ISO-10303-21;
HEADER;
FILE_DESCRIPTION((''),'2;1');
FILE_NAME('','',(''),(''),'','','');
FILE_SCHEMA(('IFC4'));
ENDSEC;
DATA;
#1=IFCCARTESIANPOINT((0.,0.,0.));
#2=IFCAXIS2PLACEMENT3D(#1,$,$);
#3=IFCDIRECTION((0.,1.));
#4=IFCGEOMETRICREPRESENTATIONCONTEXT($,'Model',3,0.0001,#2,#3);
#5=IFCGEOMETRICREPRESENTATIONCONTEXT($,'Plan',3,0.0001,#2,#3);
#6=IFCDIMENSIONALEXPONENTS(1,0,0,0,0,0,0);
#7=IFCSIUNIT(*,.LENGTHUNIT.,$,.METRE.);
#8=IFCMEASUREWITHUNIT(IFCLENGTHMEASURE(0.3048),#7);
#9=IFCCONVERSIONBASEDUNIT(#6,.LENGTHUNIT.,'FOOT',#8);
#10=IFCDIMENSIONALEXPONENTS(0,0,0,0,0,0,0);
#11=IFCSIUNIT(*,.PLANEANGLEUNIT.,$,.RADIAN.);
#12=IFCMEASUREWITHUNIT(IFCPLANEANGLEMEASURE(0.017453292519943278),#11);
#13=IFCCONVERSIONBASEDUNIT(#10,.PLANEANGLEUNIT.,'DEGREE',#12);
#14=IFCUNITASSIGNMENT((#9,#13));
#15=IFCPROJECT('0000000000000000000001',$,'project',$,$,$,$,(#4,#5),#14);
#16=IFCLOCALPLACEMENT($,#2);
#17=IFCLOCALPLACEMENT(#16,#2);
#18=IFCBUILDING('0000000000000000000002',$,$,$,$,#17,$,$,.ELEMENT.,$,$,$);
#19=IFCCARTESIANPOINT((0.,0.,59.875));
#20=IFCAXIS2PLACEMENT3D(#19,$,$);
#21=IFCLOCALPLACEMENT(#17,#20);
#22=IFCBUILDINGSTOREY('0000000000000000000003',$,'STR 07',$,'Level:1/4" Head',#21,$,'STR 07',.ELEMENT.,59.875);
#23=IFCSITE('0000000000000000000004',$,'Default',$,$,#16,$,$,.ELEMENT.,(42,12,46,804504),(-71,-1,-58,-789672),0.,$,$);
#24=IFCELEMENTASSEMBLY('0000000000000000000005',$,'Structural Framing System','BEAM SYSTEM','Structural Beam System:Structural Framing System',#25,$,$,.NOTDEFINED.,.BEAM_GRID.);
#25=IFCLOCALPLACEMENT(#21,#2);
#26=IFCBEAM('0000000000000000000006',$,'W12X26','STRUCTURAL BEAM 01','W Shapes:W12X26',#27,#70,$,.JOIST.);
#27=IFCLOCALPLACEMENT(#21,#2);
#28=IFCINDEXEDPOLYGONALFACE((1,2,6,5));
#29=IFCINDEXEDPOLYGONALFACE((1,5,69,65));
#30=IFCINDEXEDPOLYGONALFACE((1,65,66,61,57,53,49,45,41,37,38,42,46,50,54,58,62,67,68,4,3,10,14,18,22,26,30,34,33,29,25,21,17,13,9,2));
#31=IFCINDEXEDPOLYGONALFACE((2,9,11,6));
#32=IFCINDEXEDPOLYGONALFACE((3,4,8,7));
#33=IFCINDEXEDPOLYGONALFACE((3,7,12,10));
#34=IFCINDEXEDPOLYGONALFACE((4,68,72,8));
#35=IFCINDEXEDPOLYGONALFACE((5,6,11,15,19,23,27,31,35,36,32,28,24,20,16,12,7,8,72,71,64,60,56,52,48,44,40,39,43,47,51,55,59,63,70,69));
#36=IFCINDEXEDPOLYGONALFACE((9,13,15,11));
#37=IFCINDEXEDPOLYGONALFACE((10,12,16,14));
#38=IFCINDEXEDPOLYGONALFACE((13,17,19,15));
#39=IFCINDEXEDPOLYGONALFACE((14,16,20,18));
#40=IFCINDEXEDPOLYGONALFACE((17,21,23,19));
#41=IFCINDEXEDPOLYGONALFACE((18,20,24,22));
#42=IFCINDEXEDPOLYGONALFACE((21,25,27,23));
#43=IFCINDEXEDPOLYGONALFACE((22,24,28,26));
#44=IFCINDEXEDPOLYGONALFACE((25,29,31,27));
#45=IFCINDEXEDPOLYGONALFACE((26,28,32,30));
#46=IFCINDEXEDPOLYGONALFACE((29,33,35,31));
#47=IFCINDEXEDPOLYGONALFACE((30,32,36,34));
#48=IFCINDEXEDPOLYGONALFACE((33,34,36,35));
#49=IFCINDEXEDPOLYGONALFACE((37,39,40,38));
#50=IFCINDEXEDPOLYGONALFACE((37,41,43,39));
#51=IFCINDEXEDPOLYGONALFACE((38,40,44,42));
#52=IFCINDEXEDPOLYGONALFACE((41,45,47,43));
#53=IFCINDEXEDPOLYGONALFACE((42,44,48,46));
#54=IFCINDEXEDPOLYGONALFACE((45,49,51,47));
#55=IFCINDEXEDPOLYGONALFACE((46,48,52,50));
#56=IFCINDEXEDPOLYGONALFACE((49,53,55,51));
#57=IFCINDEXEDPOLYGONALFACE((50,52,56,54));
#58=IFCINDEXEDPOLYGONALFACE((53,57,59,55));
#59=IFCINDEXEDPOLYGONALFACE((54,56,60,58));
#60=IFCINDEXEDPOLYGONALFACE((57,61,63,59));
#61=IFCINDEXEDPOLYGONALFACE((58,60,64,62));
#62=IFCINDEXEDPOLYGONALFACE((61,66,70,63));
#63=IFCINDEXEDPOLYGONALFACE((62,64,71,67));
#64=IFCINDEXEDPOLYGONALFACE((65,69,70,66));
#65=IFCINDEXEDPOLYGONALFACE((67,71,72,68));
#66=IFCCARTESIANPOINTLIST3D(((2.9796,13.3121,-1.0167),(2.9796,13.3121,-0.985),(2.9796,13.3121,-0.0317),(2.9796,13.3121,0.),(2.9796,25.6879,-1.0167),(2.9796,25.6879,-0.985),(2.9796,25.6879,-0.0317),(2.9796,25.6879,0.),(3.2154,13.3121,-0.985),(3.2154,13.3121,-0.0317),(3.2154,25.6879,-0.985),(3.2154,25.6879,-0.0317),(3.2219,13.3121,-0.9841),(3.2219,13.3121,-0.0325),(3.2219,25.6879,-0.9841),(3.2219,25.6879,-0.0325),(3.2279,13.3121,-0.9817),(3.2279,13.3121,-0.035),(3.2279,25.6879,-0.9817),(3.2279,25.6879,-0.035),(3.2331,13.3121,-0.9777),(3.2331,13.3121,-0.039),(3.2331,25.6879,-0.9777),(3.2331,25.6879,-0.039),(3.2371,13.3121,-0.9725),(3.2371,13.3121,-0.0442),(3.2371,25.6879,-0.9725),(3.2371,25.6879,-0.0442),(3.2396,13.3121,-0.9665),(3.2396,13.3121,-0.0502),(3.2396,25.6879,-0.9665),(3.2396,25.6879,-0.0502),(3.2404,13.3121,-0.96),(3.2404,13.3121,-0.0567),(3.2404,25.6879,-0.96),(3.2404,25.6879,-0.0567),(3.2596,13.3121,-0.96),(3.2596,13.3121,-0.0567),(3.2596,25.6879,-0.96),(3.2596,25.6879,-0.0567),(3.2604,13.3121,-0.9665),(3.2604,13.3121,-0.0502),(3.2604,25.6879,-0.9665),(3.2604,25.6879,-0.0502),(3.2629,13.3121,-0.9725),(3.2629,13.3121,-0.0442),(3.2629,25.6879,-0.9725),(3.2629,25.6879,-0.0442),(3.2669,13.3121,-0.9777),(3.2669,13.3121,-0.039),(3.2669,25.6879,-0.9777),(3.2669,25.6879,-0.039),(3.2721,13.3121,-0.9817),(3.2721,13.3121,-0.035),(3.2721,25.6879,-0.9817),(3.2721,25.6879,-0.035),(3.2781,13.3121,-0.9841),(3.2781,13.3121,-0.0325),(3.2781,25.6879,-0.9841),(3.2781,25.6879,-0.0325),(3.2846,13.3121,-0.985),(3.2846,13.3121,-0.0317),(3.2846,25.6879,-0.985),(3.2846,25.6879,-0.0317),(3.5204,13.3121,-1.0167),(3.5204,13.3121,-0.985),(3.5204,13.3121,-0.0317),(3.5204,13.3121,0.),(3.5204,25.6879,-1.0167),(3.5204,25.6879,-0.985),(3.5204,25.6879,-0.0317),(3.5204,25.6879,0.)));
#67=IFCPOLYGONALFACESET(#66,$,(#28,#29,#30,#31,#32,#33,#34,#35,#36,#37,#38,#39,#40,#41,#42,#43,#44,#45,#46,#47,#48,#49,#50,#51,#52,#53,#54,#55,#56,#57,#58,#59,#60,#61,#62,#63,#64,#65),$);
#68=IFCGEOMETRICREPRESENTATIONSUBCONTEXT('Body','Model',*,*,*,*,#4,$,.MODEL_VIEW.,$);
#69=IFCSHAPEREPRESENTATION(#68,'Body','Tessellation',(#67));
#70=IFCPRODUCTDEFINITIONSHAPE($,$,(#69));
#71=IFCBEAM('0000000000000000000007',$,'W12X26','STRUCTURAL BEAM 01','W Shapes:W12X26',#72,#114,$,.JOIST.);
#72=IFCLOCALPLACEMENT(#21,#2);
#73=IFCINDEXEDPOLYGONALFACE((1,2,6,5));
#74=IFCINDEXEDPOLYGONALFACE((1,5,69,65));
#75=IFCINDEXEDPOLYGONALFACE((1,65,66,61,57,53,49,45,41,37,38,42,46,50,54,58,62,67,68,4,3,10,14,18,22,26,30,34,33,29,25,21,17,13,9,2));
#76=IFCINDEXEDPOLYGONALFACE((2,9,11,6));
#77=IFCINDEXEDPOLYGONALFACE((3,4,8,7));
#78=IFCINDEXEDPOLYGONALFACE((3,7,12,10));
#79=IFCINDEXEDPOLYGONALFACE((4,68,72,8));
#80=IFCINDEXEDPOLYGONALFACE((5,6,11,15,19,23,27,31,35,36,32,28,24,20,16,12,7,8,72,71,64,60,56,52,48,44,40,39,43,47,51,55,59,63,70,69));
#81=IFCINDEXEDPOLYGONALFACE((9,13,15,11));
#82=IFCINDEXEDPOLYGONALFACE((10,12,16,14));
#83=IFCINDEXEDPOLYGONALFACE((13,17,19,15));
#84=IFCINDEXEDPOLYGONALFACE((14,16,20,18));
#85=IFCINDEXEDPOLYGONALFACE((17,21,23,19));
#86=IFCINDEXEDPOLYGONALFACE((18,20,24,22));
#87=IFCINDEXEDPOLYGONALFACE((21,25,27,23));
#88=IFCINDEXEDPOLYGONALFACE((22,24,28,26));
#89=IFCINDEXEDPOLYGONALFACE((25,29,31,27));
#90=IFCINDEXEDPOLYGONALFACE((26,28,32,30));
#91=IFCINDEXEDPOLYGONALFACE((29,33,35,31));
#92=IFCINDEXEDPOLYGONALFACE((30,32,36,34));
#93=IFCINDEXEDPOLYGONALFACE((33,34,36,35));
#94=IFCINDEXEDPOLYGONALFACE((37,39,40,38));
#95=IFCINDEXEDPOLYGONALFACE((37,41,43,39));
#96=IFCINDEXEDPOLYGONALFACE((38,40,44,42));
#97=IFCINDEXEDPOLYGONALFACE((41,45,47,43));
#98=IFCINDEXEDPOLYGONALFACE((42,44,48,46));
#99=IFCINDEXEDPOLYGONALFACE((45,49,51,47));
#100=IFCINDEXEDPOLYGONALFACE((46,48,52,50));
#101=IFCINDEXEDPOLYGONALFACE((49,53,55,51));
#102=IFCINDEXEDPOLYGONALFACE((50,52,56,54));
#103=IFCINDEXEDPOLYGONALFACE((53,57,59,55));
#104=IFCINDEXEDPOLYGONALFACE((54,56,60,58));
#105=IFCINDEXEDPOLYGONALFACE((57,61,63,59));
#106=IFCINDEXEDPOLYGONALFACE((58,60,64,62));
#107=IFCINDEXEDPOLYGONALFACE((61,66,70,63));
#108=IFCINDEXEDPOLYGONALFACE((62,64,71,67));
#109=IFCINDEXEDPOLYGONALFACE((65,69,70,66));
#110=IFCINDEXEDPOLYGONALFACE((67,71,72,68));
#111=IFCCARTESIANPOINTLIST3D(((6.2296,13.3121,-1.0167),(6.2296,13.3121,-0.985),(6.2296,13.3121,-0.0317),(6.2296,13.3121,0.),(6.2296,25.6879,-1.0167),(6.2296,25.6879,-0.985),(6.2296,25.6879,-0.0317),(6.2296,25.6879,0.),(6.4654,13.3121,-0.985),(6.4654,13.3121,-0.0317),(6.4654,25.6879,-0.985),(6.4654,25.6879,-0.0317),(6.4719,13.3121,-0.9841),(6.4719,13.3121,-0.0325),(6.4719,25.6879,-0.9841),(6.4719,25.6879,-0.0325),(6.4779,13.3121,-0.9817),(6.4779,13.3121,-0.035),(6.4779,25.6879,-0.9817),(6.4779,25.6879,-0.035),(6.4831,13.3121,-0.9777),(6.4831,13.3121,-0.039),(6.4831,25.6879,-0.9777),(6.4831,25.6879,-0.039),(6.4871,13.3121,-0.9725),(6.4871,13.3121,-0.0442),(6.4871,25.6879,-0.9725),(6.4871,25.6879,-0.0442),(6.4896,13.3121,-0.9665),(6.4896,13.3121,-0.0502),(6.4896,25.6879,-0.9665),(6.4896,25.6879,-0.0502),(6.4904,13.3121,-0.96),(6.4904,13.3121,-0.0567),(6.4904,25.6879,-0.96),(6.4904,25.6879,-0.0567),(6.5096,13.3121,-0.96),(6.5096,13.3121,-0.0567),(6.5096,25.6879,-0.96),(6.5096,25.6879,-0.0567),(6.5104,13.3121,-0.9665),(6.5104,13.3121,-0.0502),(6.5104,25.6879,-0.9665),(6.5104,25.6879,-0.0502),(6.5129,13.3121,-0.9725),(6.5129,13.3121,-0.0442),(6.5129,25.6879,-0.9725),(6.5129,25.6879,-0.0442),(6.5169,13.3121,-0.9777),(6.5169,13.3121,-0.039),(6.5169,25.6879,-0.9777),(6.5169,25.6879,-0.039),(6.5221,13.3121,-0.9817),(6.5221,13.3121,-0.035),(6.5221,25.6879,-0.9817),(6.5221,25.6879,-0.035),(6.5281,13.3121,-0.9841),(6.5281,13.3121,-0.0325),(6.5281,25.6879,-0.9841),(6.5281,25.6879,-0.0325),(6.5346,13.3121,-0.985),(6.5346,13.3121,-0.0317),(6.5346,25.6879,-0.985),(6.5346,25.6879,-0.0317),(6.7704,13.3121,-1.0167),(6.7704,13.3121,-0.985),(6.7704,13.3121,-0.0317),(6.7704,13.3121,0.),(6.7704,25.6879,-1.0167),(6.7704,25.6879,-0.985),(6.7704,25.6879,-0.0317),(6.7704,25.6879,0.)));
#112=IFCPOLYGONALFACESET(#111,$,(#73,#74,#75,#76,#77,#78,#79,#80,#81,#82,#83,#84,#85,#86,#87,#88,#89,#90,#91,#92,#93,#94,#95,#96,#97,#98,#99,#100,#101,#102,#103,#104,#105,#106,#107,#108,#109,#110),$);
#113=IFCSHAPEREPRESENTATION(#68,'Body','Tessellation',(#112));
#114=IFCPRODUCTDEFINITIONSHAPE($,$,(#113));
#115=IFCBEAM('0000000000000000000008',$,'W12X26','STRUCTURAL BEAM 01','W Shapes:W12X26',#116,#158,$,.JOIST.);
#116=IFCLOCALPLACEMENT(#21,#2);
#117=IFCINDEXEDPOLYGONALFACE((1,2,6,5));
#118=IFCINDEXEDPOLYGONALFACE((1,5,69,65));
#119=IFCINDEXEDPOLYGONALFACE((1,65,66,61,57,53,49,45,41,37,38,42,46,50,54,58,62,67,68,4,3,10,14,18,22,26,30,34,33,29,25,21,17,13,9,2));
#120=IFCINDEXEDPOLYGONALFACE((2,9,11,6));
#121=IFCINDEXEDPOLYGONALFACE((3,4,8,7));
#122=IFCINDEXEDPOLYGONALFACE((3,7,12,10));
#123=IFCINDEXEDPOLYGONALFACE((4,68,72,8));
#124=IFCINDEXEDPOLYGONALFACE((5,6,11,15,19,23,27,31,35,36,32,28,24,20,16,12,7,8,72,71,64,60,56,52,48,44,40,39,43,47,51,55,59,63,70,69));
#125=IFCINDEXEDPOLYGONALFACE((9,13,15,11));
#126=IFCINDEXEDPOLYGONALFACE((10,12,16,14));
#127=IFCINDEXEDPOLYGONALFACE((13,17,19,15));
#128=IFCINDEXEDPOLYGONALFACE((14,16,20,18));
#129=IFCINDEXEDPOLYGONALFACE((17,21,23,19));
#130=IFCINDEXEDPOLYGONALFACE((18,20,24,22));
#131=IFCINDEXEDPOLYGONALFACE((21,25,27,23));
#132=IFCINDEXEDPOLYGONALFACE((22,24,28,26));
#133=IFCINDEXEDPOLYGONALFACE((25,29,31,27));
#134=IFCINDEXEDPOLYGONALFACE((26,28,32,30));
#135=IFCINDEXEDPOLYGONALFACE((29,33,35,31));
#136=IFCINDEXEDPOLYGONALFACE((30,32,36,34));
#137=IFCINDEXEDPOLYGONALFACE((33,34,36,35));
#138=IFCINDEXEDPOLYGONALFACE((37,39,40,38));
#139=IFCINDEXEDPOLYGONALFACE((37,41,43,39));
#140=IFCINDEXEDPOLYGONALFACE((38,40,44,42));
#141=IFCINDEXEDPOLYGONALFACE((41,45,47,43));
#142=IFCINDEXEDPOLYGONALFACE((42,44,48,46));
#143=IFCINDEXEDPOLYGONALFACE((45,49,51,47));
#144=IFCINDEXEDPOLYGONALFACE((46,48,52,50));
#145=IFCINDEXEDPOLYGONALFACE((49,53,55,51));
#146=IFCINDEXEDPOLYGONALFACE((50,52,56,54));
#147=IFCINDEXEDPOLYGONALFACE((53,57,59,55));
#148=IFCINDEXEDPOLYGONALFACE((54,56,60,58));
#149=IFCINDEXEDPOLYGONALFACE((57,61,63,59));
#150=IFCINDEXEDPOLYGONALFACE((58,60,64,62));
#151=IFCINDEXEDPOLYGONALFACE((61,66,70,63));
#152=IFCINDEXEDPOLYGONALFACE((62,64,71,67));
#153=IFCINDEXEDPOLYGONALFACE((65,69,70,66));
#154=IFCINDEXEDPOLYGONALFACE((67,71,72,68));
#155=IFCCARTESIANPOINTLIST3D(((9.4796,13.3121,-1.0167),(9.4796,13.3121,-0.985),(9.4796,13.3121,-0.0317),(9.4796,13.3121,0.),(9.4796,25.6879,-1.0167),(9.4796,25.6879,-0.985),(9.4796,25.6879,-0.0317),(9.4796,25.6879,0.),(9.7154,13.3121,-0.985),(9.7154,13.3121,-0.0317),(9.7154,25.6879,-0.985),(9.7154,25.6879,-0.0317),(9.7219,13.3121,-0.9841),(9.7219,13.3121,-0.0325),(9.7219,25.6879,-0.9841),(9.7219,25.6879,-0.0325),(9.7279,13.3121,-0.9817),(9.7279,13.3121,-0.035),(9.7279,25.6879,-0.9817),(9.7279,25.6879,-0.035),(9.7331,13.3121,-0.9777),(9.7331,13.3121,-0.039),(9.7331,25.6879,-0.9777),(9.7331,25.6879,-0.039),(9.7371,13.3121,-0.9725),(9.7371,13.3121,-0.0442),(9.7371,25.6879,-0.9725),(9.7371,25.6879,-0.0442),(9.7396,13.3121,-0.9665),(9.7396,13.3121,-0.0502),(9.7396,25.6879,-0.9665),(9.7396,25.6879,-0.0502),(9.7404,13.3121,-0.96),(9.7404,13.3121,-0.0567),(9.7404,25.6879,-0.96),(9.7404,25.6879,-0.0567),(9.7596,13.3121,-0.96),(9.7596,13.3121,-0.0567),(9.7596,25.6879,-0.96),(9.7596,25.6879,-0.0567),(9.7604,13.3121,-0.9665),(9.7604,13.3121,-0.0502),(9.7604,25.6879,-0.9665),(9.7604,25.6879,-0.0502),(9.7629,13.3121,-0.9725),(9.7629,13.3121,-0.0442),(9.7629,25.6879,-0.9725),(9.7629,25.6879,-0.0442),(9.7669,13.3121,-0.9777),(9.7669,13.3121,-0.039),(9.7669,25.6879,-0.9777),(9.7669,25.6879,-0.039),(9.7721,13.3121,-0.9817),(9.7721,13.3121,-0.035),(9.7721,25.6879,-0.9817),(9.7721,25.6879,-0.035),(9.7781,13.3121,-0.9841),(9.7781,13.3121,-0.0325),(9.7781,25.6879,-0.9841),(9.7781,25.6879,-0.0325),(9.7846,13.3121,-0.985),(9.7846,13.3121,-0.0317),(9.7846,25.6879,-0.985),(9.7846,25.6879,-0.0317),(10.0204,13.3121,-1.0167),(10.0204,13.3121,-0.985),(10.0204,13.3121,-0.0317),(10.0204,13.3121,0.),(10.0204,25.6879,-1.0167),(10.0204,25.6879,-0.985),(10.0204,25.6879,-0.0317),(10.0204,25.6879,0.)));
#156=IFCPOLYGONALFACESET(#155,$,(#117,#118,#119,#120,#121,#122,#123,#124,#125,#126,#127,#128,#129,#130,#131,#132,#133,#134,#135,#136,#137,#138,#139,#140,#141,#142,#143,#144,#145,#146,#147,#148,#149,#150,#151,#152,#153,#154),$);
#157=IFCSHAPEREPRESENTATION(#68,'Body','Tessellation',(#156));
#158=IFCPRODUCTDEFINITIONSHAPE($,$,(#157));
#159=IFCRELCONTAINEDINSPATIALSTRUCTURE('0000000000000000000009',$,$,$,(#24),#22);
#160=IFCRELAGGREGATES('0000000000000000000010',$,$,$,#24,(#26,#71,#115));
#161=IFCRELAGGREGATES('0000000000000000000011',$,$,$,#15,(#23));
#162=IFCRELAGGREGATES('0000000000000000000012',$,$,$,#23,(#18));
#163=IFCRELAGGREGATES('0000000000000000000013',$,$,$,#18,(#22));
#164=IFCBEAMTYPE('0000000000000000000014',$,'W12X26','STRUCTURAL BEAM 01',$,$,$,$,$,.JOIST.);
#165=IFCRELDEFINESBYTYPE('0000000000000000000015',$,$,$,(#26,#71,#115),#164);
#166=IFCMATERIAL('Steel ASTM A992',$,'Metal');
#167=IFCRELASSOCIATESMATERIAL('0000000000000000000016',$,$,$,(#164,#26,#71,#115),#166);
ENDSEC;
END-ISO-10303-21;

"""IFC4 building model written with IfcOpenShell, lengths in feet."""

from ifc_helpers import new_model, entity, si_unit, converted_unit, direction, frame, origin, place, context, subcontext, project, spatial, line, arc, indexed_curve, outline, extrude, source, transform, mapped, material, type_object, type_shapes, element, aggregate, save


model = new_model("IFC4")

# Units and contexts
model_context = context("Model", 3, precision=0.0001, world=origin(), true_north=direction((0.0, 1.0)))
plan_context = context("Plan", 3, precision=0.0001, world=origin(), true_north=direction((0.0, 1.0)))
body_context = subcontext(model_context, "Body", "Model", "MODEL_VIEW")
ifc_project = project(units=[converted_unit("LENGTHUNIT", "FOOT", entity("IfcLengthMeasure", 0.3048), si_unit("LENGTHUNIT", "METRE"), dimensions=[1, 0, 0, 0, 0, 0, 0]), converted_unit("PLANEANGLEUNIT", "DEGREE", entity("IfcPlaneAngleMeasure", 0.017453292519943278), si_unit("PLANEANGLEUNIT", "RADIAN"), dimensions=[0, 0, 0, 0, 0, 0, 0])], contexts=[model_context, plan_context])

# Site, building, storey
site_placement = place(None, origin())
site = spatial("IfcSite", under=ifc_project, at=site_placement, Name="Default", CompositionType="ELEMENT", RefLatitude=(42, 12, 46, 804504), RefLongitude=(-71, -1, -58, -789672), RefElevation=0.0)
building_placement = place(site_placement, origin())
building = spatial("IfcBuilding", under=site, at=building_placement, CompositionType="ELEMENT")
storey_placement = place(building_placement, frame((0.0, 0.0, 59.875)))
storey = spatial("IfcBuildingStorey", under=building, at=storey_placement, Name="STR 07", ObjectType="Level:1/4\" Head", LongName="STR 07", CompositionType="ELEMENT", Elevation=59.875)

# Element assembly, beams
ifc_material = material(Name="Steel ASTM A992", Category="Metal")
beam_type_1 = type_object("IfcBeamType", Name="W12X26", Description="STRUCTURAL BEAM 01", PredefinedType="JOIST", material=ifc_material)
shared_shape = source(origin(), body_context, "Body", "SweptSolid", [
    extrude(outline(indexed_curve([(-0.2704, -0.4767), (-0.2704, -0.5083), (0.2704, -0.5083), (0.2704, -0.4767), (0.0346, -0.4767), (0.0169, -0.4693), (0.0096, -0.4517), (0.0096, 0.4517), (0.0169, 0.4693), (0.0346, 0.4767), (0.2704, 0.4767), (0.2704, 0.5083), (-0.2704, 0.5083), (-0.2704, 0.4767), (-0.0346, 0.4767), (-0.0169, 0.4693), (-0.0096, 0.4517), (-0.0096, -0.4517), (-0.0169, -0.4693), (-0.0346, -0.4767)], segments=[line(1, 2, 3, 4, 5), arc(5, 6, 7), line(7, 8), arc(8, 9, 10), line(10, 11, 12, 13, 14, 15), arc(15, 16, 17), line(17, 18), arc(18, 19, 20), line(20, 1)], self_intersect=False)), frame((-6.1879, 0.0, 0.0), z_axis=(-1.0, 0.0, 0.0), x_axis=(0.0, -1.0, 0.0)), (0.0, 0.0, -1.0), 12.3758),
])
type_shapes(beam_type_1, [shared_shape])
assembly_1_placement = place(storey_placement, origin())
assembly_1 = element("IfcElementAssembly", 1, at=assembly_1_placement, inside=storey, Name="Structural Framing System", Description="BEAM SYSTEM", ObjectType="Structural Beam System:Structural Framing System", AssemblyPlace="NOTDEFINED", PredefinedType="BEAM_GRID")
beam_1_placement = place(assembly_1_placement, frame((3.25, 19.5, -0.5083), z_axis=(0.0, 0.0, 1.0), x_axis=(0.0, 1.0, 0.0)))
beam_1 = element("IfcBeam", 2, at=beam_1_placement, type_object=beam_type_1, material=ifc_material, Name="W12X26", Description="STRUCTURAL BEAM 01", ObjectType="W Shapes:W12X26", PredefinedType="JOIST", context=body_context, shape_type="MappedRepresentation", body=[
    mapped(shared_shape, transform((0.0, 0.0, 0.0), scale=1.0)),
])
beam_2_placement = place(assembly_1_placement, frame((6.5, 19.5, -0.5083), z_axis=(0.0, 0.0, 1.0), x_axis=(0.0, 1.0, 0.0)))
beam_2 = element("IfcBeam", 3, at=beam_2_placement, type_object=beam_type_1, material=ifc_material, Name="W12X26", Description="STRUCTURAL BEAM 01", ObjectType="W Shapes:W12X26", PredefinedType="JOIST", context=body_context, shape_type="MappedRepresentation", body=[
    mapped(shared_shape, transform((0.0, 0.0, 0.0), scale=1.0)),
])
beam_3_placement = place(assembly_1_placement, frame((9.75, 19.5, -0.5083), z_axis=(0.0, 0.0, 1.0), x_axis=(0.0, 1.0, 0.0)))
beam_3 = element("IfcBeam", 4, at=beam_3_placement, type_object=beam_type_1, material=ifc_material, Name="W12X26", Description="STRUCTURAL BEAM 01", ObjectType="W Shapes:W12X26", PredefinedType="JOIST", context=body_context, shape_type="MappedRepresentation", body=[
    mapped(shared_shape, transform((0.0, 0.0, 0.0), scale=1.0)),
])
aggregate(assembly_1, [beam_1, beam_2, beam_3])

save(model, "model.ifc")
